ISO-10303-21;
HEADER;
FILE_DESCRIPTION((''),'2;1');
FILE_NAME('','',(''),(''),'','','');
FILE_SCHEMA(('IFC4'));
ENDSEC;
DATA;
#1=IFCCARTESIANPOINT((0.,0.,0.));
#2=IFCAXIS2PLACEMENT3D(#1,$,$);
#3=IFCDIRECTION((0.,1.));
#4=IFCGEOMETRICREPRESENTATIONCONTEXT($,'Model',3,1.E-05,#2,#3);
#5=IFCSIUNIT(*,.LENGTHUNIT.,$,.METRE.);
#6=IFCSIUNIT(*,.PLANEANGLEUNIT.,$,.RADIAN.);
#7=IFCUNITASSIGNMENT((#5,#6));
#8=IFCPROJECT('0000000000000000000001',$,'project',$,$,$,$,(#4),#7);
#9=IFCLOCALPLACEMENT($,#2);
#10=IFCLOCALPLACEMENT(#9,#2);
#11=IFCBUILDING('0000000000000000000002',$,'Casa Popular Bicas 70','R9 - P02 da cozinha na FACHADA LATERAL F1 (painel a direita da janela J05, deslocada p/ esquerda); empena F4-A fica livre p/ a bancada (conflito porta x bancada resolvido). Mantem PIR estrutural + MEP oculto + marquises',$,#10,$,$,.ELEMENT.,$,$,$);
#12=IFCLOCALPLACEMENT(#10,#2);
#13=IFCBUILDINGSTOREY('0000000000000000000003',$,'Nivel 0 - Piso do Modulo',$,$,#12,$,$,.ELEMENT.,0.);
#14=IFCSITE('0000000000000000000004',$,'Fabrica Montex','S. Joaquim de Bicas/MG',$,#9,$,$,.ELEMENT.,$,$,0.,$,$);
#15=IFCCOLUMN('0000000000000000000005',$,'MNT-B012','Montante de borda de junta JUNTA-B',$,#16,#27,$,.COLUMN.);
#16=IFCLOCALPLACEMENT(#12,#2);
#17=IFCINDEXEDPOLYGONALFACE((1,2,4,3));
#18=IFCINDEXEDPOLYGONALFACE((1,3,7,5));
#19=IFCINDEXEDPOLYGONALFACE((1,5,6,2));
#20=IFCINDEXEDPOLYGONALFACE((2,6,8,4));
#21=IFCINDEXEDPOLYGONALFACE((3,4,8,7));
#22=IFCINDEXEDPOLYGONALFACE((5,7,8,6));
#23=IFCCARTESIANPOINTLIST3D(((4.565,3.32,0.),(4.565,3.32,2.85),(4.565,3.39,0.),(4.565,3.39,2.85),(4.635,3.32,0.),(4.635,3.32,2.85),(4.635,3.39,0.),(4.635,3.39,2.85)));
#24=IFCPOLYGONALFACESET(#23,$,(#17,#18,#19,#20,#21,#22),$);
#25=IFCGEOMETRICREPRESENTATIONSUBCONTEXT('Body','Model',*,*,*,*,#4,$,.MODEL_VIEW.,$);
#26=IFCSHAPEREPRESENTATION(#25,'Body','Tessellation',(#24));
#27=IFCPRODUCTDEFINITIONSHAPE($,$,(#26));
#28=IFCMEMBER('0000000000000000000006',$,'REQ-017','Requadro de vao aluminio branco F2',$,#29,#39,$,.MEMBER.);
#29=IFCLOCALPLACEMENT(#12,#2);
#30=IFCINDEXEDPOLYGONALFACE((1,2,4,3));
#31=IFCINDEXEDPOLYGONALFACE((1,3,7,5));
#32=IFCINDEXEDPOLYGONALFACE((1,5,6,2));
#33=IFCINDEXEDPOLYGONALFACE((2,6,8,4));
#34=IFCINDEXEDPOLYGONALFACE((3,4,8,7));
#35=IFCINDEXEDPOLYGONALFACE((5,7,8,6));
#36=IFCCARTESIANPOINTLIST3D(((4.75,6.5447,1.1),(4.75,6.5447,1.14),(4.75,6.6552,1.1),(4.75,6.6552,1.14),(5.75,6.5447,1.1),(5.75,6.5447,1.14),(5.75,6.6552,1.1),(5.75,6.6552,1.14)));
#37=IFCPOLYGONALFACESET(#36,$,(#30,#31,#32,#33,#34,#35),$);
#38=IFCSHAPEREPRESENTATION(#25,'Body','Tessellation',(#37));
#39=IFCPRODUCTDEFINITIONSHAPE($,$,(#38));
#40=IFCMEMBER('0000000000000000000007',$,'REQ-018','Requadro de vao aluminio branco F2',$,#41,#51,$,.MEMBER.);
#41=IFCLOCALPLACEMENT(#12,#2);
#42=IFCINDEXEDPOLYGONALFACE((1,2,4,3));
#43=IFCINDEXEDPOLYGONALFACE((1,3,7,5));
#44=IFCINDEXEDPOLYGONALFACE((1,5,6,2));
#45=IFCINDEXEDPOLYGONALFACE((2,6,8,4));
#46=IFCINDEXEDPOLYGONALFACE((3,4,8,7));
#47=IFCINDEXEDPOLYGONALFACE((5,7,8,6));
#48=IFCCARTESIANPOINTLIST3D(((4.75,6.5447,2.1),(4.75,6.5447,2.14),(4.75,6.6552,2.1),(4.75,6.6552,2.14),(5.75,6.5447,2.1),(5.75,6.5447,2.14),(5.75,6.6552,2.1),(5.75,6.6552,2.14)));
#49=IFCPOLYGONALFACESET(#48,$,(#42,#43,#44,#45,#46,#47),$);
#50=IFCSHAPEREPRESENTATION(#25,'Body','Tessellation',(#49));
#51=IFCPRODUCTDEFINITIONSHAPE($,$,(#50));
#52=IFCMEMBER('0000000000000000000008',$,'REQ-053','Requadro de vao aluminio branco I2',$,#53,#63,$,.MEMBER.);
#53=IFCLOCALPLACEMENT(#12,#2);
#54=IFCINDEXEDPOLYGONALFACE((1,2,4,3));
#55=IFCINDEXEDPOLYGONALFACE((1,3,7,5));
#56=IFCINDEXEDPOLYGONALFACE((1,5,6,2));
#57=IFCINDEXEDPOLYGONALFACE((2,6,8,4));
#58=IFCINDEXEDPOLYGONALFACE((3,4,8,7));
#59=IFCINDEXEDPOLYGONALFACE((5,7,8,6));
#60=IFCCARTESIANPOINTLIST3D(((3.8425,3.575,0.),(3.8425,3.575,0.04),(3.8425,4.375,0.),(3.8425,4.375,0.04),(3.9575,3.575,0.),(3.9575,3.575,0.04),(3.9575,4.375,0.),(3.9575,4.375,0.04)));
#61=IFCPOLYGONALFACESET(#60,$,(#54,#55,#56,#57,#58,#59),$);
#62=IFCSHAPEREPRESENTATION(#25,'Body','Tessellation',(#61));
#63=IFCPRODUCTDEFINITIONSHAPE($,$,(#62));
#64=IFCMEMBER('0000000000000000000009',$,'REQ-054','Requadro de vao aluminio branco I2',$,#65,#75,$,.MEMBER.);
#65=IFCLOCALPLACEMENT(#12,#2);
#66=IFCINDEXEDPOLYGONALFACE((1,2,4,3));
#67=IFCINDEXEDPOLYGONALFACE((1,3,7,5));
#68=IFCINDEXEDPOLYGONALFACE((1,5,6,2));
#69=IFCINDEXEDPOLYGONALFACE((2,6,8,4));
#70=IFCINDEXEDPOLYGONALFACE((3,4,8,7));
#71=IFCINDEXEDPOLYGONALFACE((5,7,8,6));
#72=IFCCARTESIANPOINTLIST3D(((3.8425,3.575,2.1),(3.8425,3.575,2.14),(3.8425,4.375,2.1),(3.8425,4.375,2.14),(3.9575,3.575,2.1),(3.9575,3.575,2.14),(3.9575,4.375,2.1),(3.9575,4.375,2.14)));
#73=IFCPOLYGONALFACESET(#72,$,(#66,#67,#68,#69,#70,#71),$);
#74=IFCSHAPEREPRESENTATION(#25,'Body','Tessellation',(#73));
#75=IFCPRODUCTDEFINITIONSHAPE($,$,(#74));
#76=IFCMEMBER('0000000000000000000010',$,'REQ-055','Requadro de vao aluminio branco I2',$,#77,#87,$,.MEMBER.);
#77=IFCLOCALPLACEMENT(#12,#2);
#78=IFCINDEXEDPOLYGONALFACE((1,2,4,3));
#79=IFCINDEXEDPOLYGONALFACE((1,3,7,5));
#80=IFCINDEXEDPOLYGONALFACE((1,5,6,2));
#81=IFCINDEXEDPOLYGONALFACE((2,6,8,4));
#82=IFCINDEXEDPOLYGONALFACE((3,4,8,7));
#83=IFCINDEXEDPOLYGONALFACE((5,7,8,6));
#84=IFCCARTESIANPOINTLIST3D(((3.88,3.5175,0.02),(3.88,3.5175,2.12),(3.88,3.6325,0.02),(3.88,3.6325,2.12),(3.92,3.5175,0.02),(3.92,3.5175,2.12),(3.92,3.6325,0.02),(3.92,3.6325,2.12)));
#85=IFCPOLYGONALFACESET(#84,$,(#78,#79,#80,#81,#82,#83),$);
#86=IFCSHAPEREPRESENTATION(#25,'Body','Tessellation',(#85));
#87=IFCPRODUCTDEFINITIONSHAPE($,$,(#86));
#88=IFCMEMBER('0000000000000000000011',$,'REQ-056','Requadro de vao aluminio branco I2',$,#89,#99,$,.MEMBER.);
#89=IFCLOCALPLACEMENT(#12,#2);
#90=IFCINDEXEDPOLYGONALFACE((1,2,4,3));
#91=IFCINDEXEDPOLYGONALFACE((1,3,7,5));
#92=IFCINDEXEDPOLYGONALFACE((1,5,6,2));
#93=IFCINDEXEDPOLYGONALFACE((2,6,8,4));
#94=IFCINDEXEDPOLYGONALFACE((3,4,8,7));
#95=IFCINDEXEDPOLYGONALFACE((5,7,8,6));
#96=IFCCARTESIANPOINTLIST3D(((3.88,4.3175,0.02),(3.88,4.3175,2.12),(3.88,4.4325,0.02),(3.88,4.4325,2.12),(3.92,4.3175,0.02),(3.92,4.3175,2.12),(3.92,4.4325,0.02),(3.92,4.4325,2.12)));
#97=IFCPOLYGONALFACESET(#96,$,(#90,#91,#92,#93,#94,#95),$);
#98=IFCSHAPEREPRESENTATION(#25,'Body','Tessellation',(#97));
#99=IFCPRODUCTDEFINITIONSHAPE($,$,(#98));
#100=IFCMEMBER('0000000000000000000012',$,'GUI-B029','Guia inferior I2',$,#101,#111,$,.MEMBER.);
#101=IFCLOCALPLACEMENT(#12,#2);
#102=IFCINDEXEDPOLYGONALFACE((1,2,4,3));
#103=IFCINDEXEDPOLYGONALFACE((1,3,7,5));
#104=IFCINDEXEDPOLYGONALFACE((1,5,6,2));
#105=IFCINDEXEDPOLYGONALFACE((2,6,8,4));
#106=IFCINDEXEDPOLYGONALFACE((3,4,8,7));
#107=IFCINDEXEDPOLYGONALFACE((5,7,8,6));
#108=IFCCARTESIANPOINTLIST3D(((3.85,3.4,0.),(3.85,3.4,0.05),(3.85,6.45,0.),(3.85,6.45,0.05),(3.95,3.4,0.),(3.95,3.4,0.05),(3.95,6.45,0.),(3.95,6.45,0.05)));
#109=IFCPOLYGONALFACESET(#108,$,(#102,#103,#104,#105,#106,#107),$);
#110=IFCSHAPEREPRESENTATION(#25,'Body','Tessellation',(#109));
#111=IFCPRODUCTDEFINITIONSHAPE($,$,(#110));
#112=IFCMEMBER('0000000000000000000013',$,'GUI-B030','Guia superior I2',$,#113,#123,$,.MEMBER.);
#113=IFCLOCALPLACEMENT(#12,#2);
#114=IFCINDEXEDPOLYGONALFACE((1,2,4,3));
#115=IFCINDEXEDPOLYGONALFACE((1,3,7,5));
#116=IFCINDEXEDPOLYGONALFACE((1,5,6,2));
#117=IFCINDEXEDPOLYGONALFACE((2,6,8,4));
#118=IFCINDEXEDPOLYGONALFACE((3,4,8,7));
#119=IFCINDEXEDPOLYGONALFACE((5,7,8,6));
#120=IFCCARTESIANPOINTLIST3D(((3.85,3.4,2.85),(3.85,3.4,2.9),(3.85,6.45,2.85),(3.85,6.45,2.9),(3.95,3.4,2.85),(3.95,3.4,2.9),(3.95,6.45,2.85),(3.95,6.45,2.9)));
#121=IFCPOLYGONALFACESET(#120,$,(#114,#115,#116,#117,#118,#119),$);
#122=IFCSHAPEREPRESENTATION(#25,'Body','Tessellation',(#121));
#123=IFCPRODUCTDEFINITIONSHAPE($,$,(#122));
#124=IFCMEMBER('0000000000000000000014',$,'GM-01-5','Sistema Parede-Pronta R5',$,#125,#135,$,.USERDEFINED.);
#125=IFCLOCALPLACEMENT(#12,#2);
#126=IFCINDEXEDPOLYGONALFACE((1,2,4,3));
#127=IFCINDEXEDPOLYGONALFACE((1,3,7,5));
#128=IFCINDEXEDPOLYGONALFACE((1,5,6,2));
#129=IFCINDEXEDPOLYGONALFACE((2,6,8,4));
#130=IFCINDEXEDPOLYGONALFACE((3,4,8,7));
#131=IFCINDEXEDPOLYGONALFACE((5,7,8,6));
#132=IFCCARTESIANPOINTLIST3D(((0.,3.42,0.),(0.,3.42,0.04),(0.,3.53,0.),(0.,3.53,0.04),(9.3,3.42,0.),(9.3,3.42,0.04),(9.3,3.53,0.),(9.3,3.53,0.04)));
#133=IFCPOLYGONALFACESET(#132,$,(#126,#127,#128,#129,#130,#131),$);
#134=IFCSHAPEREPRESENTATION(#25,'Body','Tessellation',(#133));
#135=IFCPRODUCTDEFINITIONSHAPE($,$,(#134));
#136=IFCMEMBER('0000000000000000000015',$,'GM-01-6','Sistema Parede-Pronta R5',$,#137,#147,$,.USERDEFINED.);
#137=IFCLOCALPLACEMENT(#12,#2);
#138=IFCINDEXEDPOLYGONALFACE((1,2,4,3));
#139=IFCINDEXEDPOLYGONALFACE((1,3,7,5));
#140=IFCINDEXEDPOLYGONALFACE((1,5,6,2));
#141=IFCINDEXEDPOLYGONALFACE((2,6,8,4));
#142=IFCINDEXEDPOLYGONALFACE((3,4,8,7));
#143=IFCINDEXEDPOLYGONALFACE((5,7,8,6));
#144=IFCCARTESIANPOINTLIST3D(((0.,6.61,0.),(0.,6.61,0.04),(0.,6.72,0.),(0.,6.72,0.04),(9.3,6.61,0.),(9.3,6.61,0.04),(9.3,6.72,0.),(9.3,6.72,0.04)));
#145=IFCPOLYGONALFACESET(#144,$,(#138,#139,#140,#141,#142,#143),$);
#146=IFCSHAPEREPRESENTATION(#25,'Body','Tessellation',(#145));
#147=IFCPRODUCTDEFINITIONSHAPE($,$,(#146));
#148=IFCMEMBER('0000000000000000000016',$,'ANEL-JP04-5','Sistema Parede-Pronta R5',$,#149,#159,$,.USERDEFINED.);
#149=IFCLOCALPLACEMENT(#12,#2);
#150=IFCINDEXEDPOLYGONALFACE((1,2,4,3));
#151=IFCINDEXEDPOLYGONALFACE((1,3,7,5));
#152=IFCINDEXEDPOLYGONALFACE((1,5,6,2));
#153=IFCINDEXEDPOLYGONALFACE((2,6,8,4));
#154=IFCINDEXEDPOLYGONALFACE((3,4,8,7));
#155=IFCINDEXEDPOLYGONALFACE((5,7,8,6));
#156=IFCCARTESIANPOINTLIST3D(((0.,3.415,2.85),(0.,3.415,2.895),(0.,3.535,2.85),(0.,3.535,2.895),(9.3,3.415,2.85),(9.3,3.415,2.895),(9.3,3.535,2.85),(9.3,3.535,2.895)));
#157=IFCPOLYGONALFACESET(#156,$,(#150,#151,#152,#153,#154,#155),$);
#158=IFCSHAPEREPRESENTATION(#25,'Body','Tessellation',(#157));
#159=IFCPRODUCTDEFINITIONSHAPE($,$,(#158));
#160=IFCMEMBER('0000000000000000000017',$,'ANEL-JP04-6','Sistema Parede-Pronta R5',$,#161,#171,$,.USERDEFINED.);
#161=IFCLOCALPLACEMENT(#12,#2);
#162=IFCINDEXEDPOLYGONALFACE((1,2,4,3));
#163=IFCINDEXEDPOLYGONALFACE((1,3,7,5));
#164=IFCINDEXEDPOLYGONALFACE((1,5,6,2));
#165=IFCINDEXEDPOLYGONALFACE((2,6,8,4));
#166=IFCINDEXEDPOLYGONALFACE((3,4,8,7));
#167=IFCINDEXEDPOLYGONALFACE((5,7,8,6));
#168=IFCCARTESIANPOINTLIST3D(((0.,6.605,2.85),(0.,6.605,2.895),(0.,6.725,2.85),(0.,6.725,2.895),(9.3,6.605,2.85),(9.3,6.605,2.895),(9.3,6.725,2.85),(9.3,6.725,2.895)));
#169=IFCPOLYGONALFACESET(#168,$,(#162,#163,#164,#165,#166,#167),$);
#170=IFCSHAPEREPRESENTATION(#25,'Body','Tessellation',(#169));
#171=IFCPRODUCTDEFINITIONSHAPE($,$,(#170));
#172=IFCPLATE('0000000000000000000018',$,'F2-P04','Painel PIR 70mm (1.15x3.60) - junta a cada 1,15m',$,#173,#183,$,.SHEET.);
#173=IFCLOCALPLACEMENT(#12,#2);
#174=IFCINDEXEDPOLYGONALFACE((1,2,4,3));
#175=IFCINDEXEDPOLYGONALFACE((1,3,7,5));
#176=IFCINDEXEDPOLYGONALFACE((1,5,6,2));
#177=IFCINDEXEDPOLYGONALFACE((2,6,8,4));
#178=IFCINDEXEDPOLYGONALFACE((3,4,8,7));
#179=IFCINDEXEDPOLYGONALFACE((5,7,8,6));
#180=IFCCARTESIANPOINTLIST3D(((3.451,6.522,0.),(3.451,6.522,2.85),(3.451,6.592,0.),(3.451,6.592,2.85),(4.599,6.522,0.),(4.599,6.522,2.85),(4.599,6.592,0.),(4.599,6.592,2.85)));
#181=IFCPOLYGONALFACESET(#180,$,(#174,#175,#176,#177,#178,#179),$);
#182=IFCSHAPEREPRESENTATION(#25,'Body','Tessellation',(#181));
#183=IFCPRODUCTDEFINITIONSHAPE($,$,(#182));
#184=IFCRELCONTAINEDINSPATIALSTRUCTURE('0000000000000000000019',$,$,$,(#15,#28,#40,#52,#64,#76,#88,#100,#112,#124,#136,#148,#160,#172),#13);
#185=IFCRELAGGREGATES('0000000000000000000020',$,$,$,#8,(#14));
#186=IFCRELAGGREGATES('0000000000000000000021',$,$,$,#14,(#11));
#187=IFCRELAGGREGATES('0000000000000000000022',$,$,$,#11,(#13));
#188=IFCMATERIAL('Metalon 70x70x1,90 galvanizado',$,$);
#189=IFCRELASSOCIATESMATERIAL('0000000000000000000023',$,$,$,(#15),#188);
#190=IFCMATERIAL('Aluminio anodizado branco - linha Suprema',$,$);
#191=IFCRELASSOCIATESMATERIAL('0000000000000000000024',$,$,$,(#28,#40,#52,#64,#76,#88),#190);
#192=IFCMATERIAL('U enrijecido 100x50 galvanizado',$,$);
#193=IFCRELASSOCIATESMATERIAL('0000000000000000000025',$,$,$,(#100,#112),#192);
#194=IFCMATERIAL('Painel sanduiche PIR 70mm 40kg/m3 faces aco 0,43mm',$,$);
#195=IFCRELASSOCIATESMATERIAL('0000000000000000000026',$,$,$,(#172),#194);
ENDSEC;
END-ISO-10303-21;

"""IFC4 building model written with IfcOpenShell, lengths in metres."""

from ifc_helpers import new_model, si_unit, direction, frame, frame_2d, origin, origin_2d, place, context, subcontext, project, spatial, rectangle, extrude, material, element, save


model = new_model("IFC4")

# Units and contexts
model_context = context("Model", 3, precision=1e-05, world=origin(), true_north=direction((0.0, 1.0)))
body_context = subcontext(model_context, "Body", "Model", "MODEL_VIEW")
ifc_project = project(units=[si_unit("LENGTHUNIT", "METRE"), si_unit("PLANEANGLEUNIT", "RADIAN")], contexts=[model_context])

# Site, building, storey
site_placement = place(None, origin())
site = spatial("IfcSite", under=ifc_project, at=site_placement, Name="Fabrica Montex", Description="S. Joaquim de Bicas/MG", CompositionType="ELEMENT", RefElevation=0.0)
building_placement = place(site_placement, origin())
building = spatial("IfcBuilding", under=site, at=building_placement, Name="Casa Popular Bicas 70", Description="R9 - P02 da cozinha na FACHADA LATERAL F1 (painel a direita da janela J05, deslocada p/ esquerda); empena F4-A fica livre p/ a bancada (conflito porta x bancada resolvido). Mantem PIR estrutural + MEP oculto + marquises", CompositionType="ELEMENT")
storey_placement = place(building_placement, origin())
storey = spatial("IfcBuildingStorey", under=building, at=storey_placement, Name="Nivel 0 - Piso do Modulo", CompositionType="ELEMENT", Elevation=0.0)

# Column
ifc_material_1 = material(Name="Metalon 70x70x1,90 galvanizado")
column_placement = place(storey_placement, frame((4.6, 3.355, 0.0)))
element("IfcColumn", 1, at=column_placement, inside=storey, material=ifc_material_1, Name="MNT-B012", Description="Montante de borda de junta JUNTA-B", PredefinedType="COLUMN", context=body_context, shape_type="SweptSolid", body=[
    extrude(rectangle(XDim=0.07, YDim=0.07, at=origin_2d()), origin(), (0.0, 0.0, 1.0), 2.85),
])

# Members
ifc_material_2 = material(Name="Aluminio anodizado branco - linha Suprema")
for number, where, z_axis, x_axis, name in (
    (2, (4.75, 6.6, 1.12), (1.0, 0.0, 0.0), (0.0, 0.0, 1.0), "REQ-017"),
    (3, (4.75, 6.6, 2.12), (1.0, 0.0, 0.0), (0.0, 0.0, 1.0), "REQ-018"),
):
    element("IfcMember", number, at=place(storey_placement, frame(where, z_axis=z_axis, x_axis=x_axis)), inside=storey, material=ifc_material_2, Name=name, Description="Requadro de vao aluminio branco F2", PredefinedType="MEMBER", context=body_context, shape_type="SweptSolid", body=[
        extrude(rectangle(XDim=0.04, YDim=0.1105, at=origin_2d()), origin(), (0.0, 0.0, 1.0), 1.0),
    ])
for number, where, z_axis, x_axis, name in (
    (4, (3.9, 3.575, 0.02), (0.0, 1.0, 0.0), (0.0, 0.0, 1.0), "REQ-053"),
    (5, (3.9, 3.575, 2.12), (0.0, 1.0, 0.0), (0.0, 0.0, 1.0), "REQ-054"),
):
    element("IfcMember", number, at=place(storey_placement, frame(where, z_axis=z_axis, x_axis=x_axis)), inside=storey, material=ifc_material_2, Name=name, Description="Requadro de vao aluminio branco I2", PredefinedType="MEMBER", context=body_context, shape_type="SweptSolid", body=[
        extrude(rectangle(XDim=0.04, YDim=0.115, at=origin_2d()), origin(), (0.0, 0.0, 1.0), 0.8),
    ])
for number, where, z_axis, x_axis, name in (
    (6, (3.9, 3.575, 0.02), (0.0, 0.0, 1.0), (1.0, 0.0, 0.0), "REQ-055"),
    (7, (3.9, 4.375, 0.02), (0.0, 0.0, 1.0), (1.0, 0.0, 0.0), "REQ-056"),
):
    element("IfcMember", number, at=place(storey_placement, frame(where, z_axis=z_axis, x_axis=x_axis)), inside=storey, material=ifc_material_2, Name=name, Description="Requadro de vao aluminio branco I2", PredefinedType="MEMBER", context=body_context, shape_type="SweptSolid", body=[
        extrude(rectangle(XDim=0.04, YDim=0.115, at=origin_2d()), origin(), (0.0, 0.0, 1.0), 2.1),
    ])
ifc_material_3 = material(Name="U enrijecido 100x50 galvanizado")
for number, where, z_axis, x_axis, name, description in (
    (8, (3.9, 3.4, 0.025), (0.0, 1.0, 0.0), (0.0, 0.0, 1.0), "GUI-B029", "Guia inferior I2"),
    (9, (3.9, 3.4, 2.875), (0.0, 1.0, 0.0), (0.0, 0.0, 1.0), "GUI-B030", "Guia superior I2"),
):
    element("IfcMember", number, at=place(storey_placement, frame(where, z_axis=z_axis, x_axis=x_axis)), inside=storey, material=ifc_material_3, Name=name, Description=description, PredefinedType="MEMBER", context=body_context, shape_type="SweptSolid", body=[
        extrude(rectangle(XDim=0.05, YDim=0.1, at=origin_2d()), origin(), (0.0, 0.0, 1.0), 3.05),
    ])
for number, where, name in (
    (10, (4.65, 3.475, 0.0), "GM-01-5"),
    (11, (4.65, 6.665, 0.0), "GM-01-6"),
):
    element("IfcMember", number, at=place(storey_placement, frame(where)), inside=storey, Name=name, Description="Sistema Parede-Pronta R5", PredefinedType="USERDEFINED", context=body_context, shape_type="SweptSolid", body=[
        extrude(rectangle(XDim=9.3, YDim=0.11, at=origin_2d()), origin(), (0.0, 0.0, 1.0), 0.04),
    ])
for number, where, name in (
    (12, (4.65, 3.475, 2.85), "ANEL-JP04-5"),
    (13, (4.65, 6.665, 2.85), "ANEL-JP04-6"),
):
    element("IfcMember", number, at=place(storey_placement, frame(where)), inside=storey, Name=name, Description="Sistema Parede-Pronta R5", PredefinedType="USERDEFINED", context=body_context, shape_type="SweptSolid", body=[
        extrude(rectangle(XDim=9.3, YDim=0.12, at=origin_2d()), origin(), (0.0, 0.0, 1.0), 0.045),
    ])

# Plate
ifc_material_4 = material(Name="Painel sanduiche PIR 70mm 40kg/m3 faces aco 0,43mm")
plate_1_placement = place(storey_placement, frame((3.451, 6.557, 0.0), x_axis=(1.0, 0.0, 0.0)))
element("IfcPlate", 14, at=plate_1_placement, inside=storey, material=ifc_material_4, Name="F2-P04", Description="Painel PIR 70mm (1.15x3.60) - junta a cada 1,15m", PredefinedType="SHEET", context=body_context, shape_type="SweptSolid", body=[
    extrude(rectangle(XDim=1.148, YDim=0.07, at=frame_2d((0.574, 0.0))), origin(), (0.0, 0.0, 1.0), 2.85),
])

save(model, "model.ifc")
